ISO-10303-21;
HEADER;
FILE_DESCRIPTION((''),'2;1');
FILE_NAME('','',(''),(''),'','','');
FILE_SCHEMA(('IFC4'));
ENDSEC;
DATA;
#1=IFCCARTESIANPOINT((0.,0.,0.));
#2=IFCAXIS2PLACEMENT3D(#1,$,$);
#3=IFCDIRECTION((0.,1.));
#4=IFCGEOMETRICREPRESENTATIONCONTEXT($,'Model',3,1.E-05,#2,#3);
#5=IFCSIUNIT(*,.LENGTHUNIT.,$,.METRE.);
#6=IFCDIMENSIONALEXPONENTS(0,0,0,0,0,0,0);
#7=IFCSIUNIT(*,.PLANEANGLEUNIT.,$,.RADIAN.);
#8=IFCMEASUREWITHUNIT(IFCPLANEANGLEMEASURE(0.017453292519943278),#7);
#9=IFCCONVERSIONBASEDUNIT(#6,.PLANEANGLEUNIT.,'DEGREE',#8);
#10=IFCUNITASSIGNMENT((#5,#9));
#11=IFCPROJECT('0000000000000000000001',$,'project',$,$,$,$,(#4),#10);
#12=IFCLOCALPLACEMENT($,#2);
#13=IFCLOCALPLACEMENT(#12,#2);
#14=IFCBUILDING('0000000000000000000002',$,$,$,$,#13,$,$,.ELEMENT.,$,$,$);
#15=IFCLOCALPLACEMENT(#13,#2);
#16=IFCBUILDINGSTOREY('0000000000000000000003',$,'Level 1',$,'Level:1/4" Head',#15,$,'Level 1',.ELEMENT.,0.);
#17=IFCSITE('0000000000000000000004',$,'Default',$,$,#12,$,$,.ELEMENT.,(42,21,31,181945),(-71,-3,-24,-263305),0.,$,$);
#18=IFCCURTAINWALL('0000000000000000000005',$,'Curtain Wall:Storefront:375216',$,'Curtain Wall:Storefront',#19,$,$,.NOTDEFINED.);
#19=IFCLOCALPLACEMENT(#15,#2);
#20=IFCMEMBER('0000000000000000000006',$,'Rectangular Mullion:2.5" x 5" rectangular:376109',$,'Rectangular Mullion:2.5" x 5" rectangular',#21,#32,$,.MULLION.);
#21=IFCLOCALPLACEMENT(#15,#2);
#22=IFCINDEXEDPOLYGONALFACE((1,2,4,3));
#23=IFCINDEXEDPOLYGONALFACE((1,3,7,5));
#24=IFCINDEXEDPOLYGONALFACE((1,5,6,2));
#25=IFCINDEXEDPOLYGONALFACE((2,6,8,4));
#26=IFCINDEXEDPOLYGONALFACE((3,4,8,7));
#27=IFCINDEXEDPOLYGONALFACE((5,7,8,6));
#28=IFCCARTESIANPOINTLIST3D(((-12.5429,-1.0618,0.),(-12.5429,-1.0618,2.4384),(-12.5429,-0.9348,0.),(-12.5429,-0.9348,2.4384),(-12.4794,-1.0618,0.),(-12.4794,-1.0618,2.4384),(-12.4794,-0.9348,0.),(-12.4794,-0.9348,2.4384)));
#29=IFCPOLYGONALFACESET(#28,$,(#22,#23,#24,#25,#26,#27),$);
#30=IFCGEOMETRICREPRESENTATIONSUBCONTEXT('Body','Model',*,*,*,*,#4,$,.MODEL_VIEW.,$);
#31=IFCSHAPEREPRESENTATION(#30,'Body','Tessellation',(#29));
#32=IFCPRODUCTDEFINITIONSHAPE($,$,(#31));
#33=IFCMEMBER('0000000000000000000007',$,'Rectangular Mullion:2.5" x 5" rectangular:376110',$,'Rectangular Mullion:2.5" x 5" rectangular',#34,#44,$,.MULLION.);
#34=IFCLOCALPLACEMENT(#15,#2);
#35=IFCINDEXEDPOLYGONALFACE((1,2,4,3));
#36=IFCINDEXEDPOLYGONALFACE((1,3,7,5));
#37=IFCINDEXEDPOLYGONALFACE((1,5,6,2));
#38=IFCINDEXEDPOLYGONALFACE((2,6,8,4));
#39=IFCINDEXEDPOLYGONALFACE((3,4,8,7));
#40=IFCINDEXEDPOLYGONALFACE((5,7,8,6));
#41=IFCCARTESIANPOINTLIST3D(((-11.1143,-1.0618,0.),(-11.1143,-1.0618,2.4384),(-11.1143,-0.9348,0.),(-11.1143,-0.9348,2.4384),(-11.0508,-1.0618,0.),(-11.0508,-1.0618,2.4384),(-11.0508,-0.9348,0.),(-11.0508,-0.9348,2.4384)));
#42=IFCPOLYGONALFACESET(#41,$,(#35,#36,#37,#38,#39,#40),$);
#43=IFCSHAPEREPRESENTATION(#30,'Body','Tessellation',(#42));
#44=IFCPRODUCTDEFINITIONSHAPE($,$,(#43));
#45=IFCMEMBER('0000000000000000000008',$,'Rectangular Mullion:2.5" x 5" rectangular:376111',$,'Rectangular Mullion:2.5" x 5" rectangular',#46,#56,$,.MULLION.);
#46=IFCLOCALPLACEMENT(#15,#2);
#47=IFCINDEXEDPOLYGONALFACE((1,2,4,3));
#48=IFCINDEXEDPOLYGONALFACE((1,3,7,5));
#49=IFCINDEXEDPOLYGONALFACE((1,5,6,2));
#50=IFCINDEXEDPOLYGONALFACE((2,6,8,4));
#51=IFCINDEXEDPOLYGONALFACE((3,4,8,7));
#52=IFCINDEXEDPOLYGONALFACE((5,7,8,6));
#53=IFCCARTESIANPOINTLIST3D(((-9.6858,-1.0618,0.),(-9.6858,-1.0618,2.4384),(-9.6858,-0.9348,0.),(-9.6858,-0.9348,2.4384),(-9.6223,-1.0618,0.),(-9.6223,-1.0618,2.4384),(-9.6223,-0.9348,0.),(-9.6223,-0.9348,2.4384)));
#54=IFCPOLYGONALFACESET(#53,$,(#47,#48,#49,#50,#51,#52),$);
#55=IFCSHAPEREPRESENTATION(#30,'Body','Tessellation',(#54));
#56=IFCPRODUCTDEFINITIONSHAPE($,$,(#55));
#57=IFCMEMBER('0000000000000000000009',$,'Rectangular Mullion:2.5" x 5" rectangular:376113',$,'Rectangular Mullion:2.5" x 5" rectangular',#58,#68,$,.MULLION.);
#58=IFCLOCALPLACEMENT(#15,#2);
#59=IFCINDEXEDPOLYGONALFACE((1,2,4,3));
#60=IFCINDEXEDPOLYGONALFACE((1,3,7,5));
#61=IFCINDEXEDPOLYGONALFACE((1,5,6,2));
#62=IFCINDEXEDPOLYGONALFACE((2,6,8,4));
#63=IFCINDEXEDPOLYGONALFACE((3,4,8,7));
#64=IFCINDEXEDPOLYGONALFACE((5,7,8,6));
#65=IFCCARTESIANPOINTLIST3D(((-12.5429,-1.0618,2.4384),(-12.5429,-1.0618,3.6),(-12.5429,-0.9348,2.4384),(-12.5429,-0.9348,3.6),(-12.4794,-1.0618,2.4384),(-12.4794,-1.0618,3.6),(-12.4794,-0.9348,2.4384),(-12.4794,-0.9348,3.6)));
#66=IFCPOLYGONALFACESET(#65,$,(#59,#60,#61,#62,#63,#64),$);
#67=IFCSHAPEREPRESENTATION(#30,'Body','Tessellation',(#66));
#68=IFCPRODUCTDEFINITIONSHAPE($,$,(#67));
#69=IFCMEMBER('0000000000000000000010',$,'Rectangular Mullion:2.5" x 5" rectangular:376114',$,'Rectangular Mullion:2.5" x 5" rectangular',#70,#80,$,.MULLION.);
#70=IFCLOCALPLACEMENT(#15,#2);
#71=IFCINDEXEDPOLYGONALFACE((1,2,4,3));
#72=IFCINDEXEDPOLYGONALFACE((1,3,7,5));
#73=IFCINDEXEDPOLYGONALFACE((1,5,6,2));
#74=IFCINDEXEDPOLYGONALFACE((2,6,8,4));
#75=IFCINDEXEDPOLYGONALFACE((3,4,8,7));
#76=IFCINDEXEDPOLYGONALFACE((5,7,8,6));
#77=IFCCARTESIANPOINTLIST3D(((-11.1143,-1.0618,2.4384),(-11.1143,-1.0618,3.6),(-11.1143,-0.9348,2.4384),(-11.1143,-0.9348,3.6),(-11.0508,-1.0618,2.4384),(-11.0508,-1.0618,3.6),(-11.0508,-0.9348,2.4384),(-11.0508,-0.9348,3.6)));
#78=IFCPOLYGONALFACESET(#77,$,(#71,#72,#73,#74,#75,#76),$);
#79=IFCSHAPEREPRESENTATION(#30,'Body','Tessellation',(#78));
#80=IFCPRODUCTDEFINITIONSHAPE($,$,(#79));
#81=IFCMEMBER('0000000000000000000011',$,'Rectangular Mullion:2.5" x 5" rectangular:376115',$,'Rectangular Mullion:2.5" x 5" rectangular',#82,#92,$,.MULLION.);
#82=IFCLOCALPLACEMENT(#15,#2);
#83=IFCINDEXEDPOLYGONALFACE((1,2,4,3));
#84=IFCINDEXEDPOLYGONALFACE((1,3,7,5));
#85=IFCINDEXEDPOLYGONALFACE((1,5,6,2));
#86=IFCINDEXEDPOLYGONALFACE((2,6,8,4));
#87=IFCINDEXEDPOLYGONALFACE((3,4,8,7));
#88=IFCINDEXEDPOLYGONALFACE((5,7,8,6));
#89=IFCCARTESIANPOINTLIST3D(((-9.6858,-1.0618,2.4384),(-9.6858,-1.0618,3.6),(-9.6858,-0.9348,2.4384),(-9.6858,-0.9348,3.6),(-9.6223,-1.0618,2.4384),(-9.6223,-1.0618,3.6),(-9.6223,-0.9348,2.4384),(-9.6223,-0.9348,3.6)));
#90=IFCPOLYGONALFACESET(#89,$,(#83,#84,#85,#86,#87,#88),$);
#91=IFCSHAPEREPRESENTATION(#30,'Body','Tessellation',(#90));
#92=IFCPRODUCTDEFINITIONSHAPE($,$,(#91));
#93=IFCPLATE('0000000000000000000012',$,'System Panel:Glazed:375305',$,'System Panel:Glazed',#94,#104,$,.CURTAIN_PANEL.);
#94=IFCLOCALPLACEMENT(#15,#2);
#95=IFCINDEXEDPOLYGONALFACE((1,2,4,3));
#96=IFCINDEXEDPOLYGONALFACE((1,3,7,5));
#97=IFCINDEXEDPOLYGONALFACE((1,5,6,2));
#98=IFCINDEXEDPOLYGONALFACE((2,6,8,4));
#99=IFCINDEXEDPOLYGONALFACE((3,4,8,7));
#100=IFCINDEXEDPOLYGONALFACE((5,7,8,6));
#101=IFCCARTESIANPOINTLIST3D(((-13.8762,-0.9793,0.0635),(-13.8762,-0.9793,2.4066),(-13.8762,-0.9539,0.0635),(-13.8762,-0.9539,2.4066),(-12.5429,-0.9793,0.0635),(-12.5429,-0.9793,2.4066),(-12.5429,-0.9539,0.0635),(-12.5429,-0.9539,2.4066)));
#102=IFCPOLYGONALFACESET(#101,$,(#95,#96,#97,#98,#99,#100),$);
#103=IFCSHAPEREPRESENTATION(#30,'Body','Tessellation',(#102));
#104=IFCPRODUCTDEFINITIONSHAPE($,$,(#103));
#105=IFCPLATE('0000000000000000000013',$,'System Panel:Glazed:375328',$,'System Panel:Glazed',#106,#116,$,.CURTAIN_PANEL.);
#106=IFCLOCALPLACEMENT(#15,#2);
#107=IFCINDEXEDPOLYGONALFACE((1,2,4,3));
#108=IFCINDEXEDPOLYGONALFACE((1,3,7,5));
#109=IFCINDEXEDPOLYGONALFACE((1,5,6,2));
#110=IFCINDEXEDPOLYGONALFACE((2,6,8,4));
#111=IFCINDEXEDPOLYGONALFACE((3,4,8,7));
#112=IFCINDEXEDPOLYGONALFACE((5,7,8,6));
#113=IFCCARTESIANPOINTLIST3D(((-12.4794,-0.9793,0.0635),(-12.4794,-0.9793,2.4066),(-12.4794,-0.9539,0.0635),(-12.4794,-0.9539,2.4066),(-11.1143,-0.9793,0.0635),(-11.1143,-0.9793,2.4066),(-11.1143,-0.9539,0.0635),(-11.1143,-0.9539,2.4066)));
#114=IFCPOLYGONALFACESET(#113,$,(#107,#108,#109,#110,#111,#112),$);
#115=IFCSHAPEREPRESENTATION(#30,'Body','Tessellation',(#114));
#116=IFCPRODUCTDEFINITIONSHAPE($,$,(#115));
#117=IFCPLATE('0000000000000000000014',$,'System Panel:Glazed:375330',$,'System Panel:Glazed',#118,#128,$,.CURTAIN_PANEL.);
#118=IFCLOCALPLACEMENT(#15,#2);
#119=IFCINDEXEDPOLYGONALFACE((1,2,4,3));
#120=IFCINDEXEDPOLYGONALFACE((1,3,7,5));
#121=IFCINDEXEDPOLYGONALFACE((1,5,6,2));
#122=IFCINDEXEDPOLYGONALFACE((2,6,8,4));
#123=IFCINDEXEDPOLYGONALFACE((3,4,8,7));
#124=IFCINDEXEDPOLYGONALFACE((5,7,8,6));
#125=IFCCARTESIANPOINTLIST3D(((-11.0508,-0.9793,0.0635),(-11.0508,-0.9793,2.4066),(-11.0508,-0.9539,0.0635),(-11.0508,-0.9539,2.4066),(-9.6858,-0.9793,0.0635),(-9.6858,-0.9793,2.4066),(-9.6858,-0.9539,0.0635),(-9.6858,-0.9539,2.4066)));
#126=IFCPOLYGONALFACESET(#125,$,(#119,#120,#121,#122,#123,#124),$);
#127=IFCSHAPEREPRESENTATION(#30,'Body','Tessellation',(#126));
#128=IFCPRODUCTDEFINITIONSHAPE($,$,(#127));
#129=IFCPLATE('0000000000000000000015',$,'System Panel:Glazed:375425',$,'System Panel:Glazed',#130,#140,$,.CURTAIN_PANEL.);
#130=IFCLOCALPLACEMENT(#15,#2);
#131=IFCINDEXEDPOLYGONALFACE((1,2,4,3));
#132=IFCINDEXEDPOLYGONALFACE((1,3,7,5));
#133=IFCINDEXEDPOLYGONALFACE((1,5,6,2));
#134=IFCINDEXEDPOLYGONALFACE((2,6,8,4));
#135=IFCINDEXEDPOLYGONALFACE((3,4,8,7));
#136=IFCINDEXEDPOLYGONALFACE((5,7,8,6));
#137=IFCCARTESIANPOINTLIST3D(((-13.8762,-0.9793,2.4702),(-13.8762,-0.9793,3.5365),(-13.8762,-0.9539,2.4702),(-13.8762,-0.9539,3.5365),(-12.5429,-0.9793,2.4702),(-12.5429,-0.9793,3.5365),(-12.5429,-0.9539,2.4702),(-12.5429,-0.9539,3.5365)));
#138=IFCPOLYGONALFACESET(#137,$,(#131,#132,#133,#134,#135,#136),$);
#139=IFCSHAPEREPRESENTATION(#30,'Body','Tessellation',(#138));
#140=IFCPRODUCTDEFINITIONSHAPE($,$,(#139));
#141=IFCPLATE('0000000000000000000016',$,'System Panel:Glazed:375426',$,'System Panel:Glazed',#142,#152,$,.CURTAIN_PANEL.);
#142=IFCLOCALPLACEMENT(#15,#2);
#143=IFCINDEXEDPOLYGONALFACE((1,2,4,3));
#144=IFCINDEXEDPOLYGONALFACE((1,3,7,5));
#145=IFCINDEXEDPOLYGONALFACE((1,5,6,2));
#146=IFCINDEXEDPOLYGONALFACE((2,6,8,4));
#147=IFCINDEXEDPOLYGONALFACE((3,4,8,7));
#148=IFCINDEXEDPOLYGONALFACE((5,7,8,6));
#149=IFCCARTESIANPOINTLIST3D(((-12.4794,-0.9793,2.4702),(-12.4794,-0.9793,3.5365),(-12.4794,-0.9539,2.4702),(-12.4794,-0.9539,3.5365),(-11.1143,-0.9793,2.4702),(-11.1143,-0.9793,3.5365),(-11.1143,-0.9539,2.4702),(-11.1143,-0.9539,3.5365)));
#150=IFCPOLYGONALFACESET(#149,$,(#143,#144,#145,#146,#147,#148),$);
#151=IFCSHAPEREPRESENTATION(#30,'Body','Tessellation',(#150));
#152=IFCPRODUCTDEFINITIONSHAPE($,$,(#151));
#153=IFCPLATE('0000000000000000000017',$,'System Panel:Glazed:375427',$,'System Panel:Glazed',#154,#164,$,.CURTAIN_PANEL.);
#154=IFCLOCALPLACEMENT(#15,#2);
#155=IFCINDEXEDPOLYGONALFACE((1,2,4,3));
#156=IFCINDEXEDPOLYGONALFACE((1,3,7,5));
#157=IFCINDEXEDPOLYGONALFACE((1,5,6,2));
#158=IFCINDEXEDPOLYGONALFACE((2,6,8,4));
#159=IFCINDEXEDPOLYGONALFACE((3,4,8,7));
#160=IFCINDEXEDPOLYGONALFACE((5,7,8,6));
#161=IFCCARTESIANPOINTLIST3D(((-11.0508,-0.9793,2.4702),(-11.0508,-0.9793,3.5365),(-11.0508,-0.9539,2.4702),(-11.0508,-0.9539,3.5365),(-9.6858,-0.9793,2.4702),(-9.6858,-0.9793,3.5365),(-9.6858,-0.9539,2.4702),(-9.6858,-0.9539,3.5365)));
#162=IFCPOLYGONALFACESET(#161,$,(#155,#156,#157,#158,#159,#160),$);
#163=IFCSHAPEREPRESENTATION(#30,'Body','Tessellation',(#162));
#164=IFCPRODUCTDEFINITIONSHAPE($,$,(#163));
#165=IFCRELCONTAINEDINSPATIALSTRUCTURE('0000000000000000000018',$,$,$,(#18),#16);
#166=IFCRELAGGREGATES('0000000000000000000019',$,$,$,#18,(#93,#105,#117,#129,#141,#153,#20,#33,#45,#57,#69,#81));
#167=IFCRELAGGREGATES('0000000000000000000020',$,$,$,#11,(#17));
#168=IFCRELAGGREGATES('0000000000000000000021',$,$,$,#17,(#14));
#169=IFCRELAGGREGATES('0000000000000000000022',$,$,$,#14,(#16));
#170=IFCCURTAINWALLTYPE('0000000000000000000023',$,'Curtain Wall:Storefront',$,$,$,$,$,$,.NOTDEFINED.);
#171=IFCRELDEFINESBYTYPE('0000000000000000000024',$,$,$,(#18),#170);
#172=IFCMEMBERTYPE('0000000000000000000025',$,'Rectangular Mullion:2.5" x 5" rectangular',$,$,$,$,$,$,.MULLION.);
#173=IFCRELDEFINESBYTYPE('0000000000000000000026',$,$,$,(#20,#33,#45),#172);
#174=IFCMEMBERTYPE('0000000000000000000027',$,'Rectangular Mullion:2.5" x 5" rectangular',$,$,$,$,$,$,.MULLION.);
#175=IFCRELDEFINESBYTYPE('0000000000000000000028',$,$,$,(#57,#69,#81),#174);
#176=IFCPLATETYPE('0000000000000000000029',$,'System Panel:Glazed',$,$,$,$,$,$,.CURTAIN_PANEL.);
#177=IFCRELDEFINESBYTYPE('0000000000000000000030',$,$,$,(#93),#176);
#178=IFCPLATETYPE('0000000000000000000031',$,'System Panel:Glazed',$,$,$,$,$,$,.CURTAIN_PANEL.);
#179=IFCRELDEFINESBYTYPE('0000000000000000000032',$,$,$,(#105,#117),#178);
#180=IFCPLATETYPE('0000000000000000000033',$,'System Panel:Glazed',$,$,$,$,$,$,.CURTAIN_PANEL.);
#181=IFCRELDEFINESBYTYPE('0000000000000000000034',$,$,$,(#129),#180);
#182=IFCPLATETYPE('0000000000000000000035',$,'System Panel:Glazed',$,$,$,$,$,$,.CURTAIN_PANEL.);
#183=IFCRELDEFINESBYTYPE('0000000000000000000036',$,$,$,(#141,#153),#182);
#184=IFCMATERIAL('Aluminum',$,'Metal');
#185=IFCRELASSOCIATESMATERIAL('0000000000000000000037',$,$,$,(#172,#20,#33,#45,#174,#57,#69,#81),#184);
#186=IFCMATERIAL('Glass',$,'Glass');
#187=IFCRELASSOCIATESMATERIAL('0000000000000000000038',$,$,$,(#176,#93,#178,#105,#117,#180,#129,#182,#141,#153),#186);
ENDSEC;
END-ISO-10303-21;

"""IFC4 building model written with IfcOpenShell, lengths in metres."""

from ifc_helpers import new_model, entity, si_unit, converted_unit, direction, frame, origin, place, context, subcontext, project, spatial, indexed_curve, outline, extrude, source, transform, mapped, material, type_object, type_shapes, element, aggregate, save


model = new_model("IFC4")

# Units and contexts
model_context = context("Model", 3, precision=1e-05, world=origin(), true_north=direction((0.0, 1.0)))
body_context = subcontext(model_context, "Body", "Model", "MODEL_VIEW")
ifc_project = project(units=[si_unit("LENGTHUNIT", "METRE"), converted_unit("PLANEANGLEUNIT", "DEGREE", entity("IfcPlaneAngleMeasure", 0.017453292519943278), si_unit("PLANEANGLEUNIT", "RADIAN"), dimensions=[0, 0, 0, 0, 0, 0, 0])], contexts=[model_context])

# Site, building, storey
site_placement = place(None, origin())
site = spatial("IfcSite", under=ifc_project, at=site_placement, Name="Default", CompositionType="ELEMENT", RefLatitude=(42, 21, 31, 181945), RefLongitude=(-71, -3, -24, -263305), RefElevation=0.0)
building_placement = place(site_placement, origin())
building = spatial("IfcBuilding", under=site, at=building_placement, CompositionType="ELEMENT")
storey_placement = place(building_placement, origin())
storey = spatial("IfcBuildingStorey", under=building, at=storey_placement, Name="Level 1", ObjectType="Level:1/4\" Head", LongName="Level 1", CompositionType="ELEMENT", Elevation=0.0)

# Curtain wall, members, plates
curtain_wall_type = type_object("IfcCurtainWallType", Name="Curtain Wall:Storefront", PredefinedType="NOTDEFINED")
curtain_wall_placement = place(storey_placement, origin())
curtain_wall = element("IfcCurtainWall", 1, at=curtain_wall_placement, inside=storey, type_object=curtain_wall_type, Name="Curtain Wall:Storefront:375216", ObjectType="Curtain Wall:Storefront", PredefinedType="NOTDEFINED")
ifc_material_1 = material(Name="Aluminum", Category="Metal")
member_type_1 = type_object("IfcMemberType", Name="Rectangular Mullion:2.5\" x 5\" rectangular", PredefinedType="MULLION", material=ifc_material_1)
shared_shape_1 = source(origin(), body_context, "Body", "SweptSolid", [
    extrude(outline(indexed_curve([(-0.0318, -0.0635), (0.0318, -0.0635), (0.0318, 0.0635), (-0.0318, 0.0635), (-0.0318, -0.0635)], self_intersect=False)), frame((0.0, 0.0, -2.4384), z_axis=(0.0, 0.0, 1.0), x_axis=(-1.0, 0.0, 0.0)), (0.0, 0.0, 1.0), 2.4384),
])
type_shapes(member_type_1, [shared_shape_1])
member_1_placement = place(curtain_wall_placement, frame((-12.5112, -0.9983, 0.0), z_axis=(0.0, 0.0, -1.0), x_axis=(1.0, 0.0, 0.0)))
member_1 = element("IfcMember", 2, at=member_1_placement, type_object=member_type_1, material=ifc_material_1, Name="Rectangular Mullion:2.5\" x 5\" rectangular:376109", ObjectType="Rectangular Mullion:2.5\" x 5\" rectangular", PredefinedType="MULLION", context=body_context, shape_type="MappedRepresentation", body=[
    mapped(shared_shape_1, transform((0.0, 0.0, 0.0), scale=1.0)),
])
member_2_placement = place(curtain_wall_placement, frame((-11.0826, -0.9983, 0.0), z_axis=(0.0, 0.0, -1.0), x_axis=(1.0, 0.0, 0.0)))
member_2 = element("IfcMember", 3, at=member_2_placement, type_object=member_type_1, material=ifc_material_1, Name="Rectangular Mullion:2.5\" x 5\" rectangular:376110", ObjectType="Rectangular Mullion:2.5\" x 5\" rectangular", PredefinedType="MULLION", context=body_context, shape_type="MappedRepresentation", body=[
    mapped(shared_shape_1, transform((0.0, 0.0, 0.0), scale=1.0)),
])
member_3_placement = place(curtain_wall_placement, frame((-9.654, -0.9983, 0.0), z_axis=(0.0, 0.0, -1.0), x_axis=(1.0, 0.0, 0.0)))
member_3 = element("IfcMember", 4, at=member_3_placement, type_object=member_type_1, material=ifc_material_1, Name="Rectangular Mullion:2.5\" x 5\" rectangular:376111", ObjectType="Rectangular Mullion:2.5\" x 5\" rectangular", PredefinedType="MULLION", context=body_context, shape_type="MappedRepresentation", body=[
    mapped(shared_shape_1, transform((0.0, 0.0, 0.0), scale=1.0)),
])
member_type_2 = type_object("IfcMemberType", Name="Rectangular Mullion:2.5\" x 5\" rectangular", PredefinedType="MULLION", material=ifc_material_1)
shared_shape_2 = source(origin(), body_context, "Body", "SweptSolid", [
    extrude(outline(indexed_curve([(-0.0318, -0.0635), (0.0318, -0.0635), (0.0318, 0.0635), (-0.0318, 0.0635), (-0.0318, -0.0635)], self_intersect=False)), frame((0.0, 0.0, -1.1616), z_axis=(0.0, 0.0, 1.0), x_axis=(-1.0, 0.0, 0.0)), (0.0, 0.0, 1.0), 1.1616),
])
type_shapes(member_type_2, [shared_shape_2])
member_4_placement = place(curtain_wall_placement, frame((-12.5112, -0.9983, 2.4384), z_axis=(0.0, 0.0, -1.0), x_axis=(1.0, 0.0, 0.0)))
member_4 = element("IfcMember", 5, at=member_4_placement, type_object=member_type_2, material=ifc_material_1, Name="Rectangular Mullion:2.5\" x 5\" rectangular:376113", ObjectType="Rectangular Mullion:2.5\" x 5\" rectangular", PredefinedType="MULLION", context=body_context, shape_type="MappedRepresentation", body=[
    mapped(shared_shape_2, transform((0.0, 0.0, 0.0), scale=1.0)),
])
member_5_placement = place(curtain_wall_placement, frame((-11.0826, -0.9983, 2.4384), z_axis=(0.0, 0.0, -1.0), x_axis=(1.0, 0.0, 0.0)))
member_5 = element("IfcMember", 6, at=member_5_placement, type_object=member_type_2, material=ifc_material_1, Name="Rectangular Mullion:2.5\" x 5\" rectangular:376114", ObjectType="Rectangular Mullion:2.5\" x 5\" rectangular", PredefinedType="MULLION", context=body_context, shape_type="MappedRepresentation", body=[
    mapped(shared_shape_2, transform((0.0, 0.0, 0.0), scale=1.0)),
])
member_6_placement = place(curtain_wall_placement, frame((-9.654, -0.9983, 2.4384), z_axis=(0.0, 0.0, -1.0), x_axis=(1.0, 0.0, 0.0)))
member_6 = element("IfcMember", 7, at=member_6_placement, type_object=member_type_2, material=ifc_material_1, Name="Rectangular Mullion:2.5\" x 5\" rectangular:376115", ObjectType="Rectangular Mullion:2.5\" x 5\" rectangular", PredefinedType="MULLION", context=body_context, shape_type="MappedRepresentation", body=[
    mapped(shared_shape_2, transform((0.0, 0.0, 0.0), scale=1.0)),
])
ifc_material_2 = material(Name="Glass", Category="Glass")
plate_type_1 = type_object("IfcPlateType", Name="System Panel:Glazed", PredefinedType="CURTAIN_PANEL", material=ifc_material_2)
shared_shape_3 = source(origin(), body_context, "Body", "SweptSolid", [
    extrude(outline(indexed_curve([(-0.0127, -0.6667), (0.0127, -0.6667), (0.0127, 0.6667), (-0.0127, 0.6667), (-0.0127, -0.6667)], self_intersect=False)), frame((0.0, 0.0318, 0.0), z_axis=(0.0, 0.0, 1.0), x_axis=(0.0, 1.0, 0.0)), (0.0, 0.0, 1.0), 2.3432),
])
type_shapes(plate_type_1, [shared_shape_3])
plate_1_placement = place(curtain_wall_placement, frame((-13.2096, -0.9983, 0.0635)))
plate_1 = element("IfcPlate", 8, at=plate_1_placement, type_object=plate_type_1, material=ifc_material_2, Name="System Panel:Glazed:375305", ObjectType="System Panel:Glazed", PredefinedType="CURTAIN_PANEL", context=body_context, shape_type="MappedRepresentation", body=[
    mapped(shared_shape_3, transform((0.0, 0.0, 0.0), scale=1.0)),
])
plate_type_2 = type_object("IfcPlateType", Name="System Panel:Glazed", PredefinedType="CURTAIN_PANEL", material=ifc_material_2)
shared_shape_4 = source(origin(), body_context, "Body", "SweptSolid", [
    extrude(outline(indexed_curve([(-0.0127, -0.6825), (0.0127, -0.6825), (0.0127, 0.6825), (-0.0127, 0.6825), (-0.0127, -0.6825)], self_intersect=False)), frame((0.0, 0.0318, 0.0), z_axis=(0.0, 0.0, 1.0), x_axis=(0.0, 1.0, 0.0)), (0.0, 0.0, 1.0), 2.3432),
])
type_shapes(plate_type_2, [shared_shape_4])
plate_2_placement = place(curtain_wall_placement, frame((-11.7969, -0.9983, 0.0635)))
plate_2 = element("IfcPlate", 9, at=plate_2_placement, type_object=plate_type_2, material=ifc_material_2, Name="System Panel:Glazed:375328", ObjectType="System Panel:Glazed", PredefinedType="CURTAIN_PANEL", context=body_context, shape_type="MappedRepresentation", body=[
    mapped(shared_shape_4, transform((0.0, 0.0, 0.0), scale=1.0)),
])
plate_3_placement = place(curtain_wall_placement, frame((-10.3683, -0.9983, 0.0635)))
plate_3 = element("IfcPlate", 10, at=plate_3_placement, type_object=plate_type_2, material=ifc_material_2, Name="System Panel:Glazed:375330", ObjectType="System Panel:Glazed", PredefinedType="CURTAIN_PANEL", context=body_context, shape_type="MappedRepresentation", body=[
    mapped(shared_shape_4, transform((0.0, 0.0, 0.0), scale=1.0)),
])
plate_type_3 = type_object("IfcPlateType", Name="System Panel:Glazed", PredefinedType="CURTAIN_PANEL", material=ifc_material_2)
shared_shape_5 = source(origin(), body_context, "Body", "SweptSolid", [
    extrude(outline(indexed_curve([(-0.0127, -0.6667), (0.0127, -0.6667), (0.0127, 0.6667), (-0.0127, 0.6667), (-0.0127, -0.6667)], self_intersect=False)), frame((0.0, 0.0318, 0.0), z_axis=(0.0, 0.0, 1.0), x_axis=(0.0, 1.0, 0.0)), (0.0, 0.0, 1.0), 1.0663),
])
type_shapes(plate_type_3, [shared_shape_5])
plate_4_placement = place(curtain_wall_placement, frame((-13.2096, -0.9983, 2.4701)))
plate_4 = element("IfcPlate", 11, at=plate_4_placement, type_object=plate_type_3, material=ifc_material_2, Name="System Panel:Glazed:375425", ObjectType="System Panel:Glazed", PredefinedType="CURTAIN_PANEL", context=body_context, shape_type="MappedRepresentation", body=[
    mapped(shared_shape_5, transform((0.0, 0.0, 0.0), scale=1.0)),
])
plate_type_4 = type_object("IfcPlateType", Name="System Panel:Glazed", PredefinedType="CURTAIN_PANEL", material=ifc_material_2)
shared_shape_6 = source(origin(), body_context, "Body", "SweptSolid", [
    extrude(outline(indexed_curve([(-0.0127, -0.6825), (0.0127, -0.6825), (0.0127, 0.6825), (-0.0127, 0.6825), (-0.0127, -0.6825)], self_intersect=False)), frame((0.0, 0.0318, 0.0), z_axis=(0.0, 0.0, 1.0), x_axis=(0.0, 1.0, 0.0)), (0.0, 0.0, 1.0), 1.0663),
])
type_shapes(plate_type_4, [shared_shape_6])
plate_5_placement = place(curtain_wall_placement, frame((-11.7969, -0.9983, 2.4701)))
plate_5 = element("IfcPlate", 12, at=plate_5_placement, type_object=plate_type_4, material=ifc_material_2, Name="System Panel:Glazed:375426", ObjectType="System Panel:Glazed", PredefinedType="CURTAIN_PANEL", context=body_context, shape_type="MappedRepresentation", body=[
    mapped(shared_shape_6, transform((0.0, 0.0, 0.0), scale=1.0)),
])
plate_6_placement = place(curtain_wall_placement, frame((-10.3683, -0.9983, 2.4701)))
plate_6 = element("IfcPlate", 13, at=plate_6_placement, type_object=plate_type_4, material=ifc_material_2, Name="System Panel:Glazed:375427", ObjectType="System Panel:Glazed", PredefinedType="CURTAIN_PANEL", context=body_context, shape_type="MappedRepresentation", body=[
    mapped(shared_shape_6, transform((0.0, 0.0, 0.0), scale=1.0)),
])
aggregate(curtain_wall, [plate_1, plate_2, plate_3, plate_4, plate_5, plate_6, member_1, member_2, member_3, member_4, member_5, member_6])

save(model, "model.ifc")
